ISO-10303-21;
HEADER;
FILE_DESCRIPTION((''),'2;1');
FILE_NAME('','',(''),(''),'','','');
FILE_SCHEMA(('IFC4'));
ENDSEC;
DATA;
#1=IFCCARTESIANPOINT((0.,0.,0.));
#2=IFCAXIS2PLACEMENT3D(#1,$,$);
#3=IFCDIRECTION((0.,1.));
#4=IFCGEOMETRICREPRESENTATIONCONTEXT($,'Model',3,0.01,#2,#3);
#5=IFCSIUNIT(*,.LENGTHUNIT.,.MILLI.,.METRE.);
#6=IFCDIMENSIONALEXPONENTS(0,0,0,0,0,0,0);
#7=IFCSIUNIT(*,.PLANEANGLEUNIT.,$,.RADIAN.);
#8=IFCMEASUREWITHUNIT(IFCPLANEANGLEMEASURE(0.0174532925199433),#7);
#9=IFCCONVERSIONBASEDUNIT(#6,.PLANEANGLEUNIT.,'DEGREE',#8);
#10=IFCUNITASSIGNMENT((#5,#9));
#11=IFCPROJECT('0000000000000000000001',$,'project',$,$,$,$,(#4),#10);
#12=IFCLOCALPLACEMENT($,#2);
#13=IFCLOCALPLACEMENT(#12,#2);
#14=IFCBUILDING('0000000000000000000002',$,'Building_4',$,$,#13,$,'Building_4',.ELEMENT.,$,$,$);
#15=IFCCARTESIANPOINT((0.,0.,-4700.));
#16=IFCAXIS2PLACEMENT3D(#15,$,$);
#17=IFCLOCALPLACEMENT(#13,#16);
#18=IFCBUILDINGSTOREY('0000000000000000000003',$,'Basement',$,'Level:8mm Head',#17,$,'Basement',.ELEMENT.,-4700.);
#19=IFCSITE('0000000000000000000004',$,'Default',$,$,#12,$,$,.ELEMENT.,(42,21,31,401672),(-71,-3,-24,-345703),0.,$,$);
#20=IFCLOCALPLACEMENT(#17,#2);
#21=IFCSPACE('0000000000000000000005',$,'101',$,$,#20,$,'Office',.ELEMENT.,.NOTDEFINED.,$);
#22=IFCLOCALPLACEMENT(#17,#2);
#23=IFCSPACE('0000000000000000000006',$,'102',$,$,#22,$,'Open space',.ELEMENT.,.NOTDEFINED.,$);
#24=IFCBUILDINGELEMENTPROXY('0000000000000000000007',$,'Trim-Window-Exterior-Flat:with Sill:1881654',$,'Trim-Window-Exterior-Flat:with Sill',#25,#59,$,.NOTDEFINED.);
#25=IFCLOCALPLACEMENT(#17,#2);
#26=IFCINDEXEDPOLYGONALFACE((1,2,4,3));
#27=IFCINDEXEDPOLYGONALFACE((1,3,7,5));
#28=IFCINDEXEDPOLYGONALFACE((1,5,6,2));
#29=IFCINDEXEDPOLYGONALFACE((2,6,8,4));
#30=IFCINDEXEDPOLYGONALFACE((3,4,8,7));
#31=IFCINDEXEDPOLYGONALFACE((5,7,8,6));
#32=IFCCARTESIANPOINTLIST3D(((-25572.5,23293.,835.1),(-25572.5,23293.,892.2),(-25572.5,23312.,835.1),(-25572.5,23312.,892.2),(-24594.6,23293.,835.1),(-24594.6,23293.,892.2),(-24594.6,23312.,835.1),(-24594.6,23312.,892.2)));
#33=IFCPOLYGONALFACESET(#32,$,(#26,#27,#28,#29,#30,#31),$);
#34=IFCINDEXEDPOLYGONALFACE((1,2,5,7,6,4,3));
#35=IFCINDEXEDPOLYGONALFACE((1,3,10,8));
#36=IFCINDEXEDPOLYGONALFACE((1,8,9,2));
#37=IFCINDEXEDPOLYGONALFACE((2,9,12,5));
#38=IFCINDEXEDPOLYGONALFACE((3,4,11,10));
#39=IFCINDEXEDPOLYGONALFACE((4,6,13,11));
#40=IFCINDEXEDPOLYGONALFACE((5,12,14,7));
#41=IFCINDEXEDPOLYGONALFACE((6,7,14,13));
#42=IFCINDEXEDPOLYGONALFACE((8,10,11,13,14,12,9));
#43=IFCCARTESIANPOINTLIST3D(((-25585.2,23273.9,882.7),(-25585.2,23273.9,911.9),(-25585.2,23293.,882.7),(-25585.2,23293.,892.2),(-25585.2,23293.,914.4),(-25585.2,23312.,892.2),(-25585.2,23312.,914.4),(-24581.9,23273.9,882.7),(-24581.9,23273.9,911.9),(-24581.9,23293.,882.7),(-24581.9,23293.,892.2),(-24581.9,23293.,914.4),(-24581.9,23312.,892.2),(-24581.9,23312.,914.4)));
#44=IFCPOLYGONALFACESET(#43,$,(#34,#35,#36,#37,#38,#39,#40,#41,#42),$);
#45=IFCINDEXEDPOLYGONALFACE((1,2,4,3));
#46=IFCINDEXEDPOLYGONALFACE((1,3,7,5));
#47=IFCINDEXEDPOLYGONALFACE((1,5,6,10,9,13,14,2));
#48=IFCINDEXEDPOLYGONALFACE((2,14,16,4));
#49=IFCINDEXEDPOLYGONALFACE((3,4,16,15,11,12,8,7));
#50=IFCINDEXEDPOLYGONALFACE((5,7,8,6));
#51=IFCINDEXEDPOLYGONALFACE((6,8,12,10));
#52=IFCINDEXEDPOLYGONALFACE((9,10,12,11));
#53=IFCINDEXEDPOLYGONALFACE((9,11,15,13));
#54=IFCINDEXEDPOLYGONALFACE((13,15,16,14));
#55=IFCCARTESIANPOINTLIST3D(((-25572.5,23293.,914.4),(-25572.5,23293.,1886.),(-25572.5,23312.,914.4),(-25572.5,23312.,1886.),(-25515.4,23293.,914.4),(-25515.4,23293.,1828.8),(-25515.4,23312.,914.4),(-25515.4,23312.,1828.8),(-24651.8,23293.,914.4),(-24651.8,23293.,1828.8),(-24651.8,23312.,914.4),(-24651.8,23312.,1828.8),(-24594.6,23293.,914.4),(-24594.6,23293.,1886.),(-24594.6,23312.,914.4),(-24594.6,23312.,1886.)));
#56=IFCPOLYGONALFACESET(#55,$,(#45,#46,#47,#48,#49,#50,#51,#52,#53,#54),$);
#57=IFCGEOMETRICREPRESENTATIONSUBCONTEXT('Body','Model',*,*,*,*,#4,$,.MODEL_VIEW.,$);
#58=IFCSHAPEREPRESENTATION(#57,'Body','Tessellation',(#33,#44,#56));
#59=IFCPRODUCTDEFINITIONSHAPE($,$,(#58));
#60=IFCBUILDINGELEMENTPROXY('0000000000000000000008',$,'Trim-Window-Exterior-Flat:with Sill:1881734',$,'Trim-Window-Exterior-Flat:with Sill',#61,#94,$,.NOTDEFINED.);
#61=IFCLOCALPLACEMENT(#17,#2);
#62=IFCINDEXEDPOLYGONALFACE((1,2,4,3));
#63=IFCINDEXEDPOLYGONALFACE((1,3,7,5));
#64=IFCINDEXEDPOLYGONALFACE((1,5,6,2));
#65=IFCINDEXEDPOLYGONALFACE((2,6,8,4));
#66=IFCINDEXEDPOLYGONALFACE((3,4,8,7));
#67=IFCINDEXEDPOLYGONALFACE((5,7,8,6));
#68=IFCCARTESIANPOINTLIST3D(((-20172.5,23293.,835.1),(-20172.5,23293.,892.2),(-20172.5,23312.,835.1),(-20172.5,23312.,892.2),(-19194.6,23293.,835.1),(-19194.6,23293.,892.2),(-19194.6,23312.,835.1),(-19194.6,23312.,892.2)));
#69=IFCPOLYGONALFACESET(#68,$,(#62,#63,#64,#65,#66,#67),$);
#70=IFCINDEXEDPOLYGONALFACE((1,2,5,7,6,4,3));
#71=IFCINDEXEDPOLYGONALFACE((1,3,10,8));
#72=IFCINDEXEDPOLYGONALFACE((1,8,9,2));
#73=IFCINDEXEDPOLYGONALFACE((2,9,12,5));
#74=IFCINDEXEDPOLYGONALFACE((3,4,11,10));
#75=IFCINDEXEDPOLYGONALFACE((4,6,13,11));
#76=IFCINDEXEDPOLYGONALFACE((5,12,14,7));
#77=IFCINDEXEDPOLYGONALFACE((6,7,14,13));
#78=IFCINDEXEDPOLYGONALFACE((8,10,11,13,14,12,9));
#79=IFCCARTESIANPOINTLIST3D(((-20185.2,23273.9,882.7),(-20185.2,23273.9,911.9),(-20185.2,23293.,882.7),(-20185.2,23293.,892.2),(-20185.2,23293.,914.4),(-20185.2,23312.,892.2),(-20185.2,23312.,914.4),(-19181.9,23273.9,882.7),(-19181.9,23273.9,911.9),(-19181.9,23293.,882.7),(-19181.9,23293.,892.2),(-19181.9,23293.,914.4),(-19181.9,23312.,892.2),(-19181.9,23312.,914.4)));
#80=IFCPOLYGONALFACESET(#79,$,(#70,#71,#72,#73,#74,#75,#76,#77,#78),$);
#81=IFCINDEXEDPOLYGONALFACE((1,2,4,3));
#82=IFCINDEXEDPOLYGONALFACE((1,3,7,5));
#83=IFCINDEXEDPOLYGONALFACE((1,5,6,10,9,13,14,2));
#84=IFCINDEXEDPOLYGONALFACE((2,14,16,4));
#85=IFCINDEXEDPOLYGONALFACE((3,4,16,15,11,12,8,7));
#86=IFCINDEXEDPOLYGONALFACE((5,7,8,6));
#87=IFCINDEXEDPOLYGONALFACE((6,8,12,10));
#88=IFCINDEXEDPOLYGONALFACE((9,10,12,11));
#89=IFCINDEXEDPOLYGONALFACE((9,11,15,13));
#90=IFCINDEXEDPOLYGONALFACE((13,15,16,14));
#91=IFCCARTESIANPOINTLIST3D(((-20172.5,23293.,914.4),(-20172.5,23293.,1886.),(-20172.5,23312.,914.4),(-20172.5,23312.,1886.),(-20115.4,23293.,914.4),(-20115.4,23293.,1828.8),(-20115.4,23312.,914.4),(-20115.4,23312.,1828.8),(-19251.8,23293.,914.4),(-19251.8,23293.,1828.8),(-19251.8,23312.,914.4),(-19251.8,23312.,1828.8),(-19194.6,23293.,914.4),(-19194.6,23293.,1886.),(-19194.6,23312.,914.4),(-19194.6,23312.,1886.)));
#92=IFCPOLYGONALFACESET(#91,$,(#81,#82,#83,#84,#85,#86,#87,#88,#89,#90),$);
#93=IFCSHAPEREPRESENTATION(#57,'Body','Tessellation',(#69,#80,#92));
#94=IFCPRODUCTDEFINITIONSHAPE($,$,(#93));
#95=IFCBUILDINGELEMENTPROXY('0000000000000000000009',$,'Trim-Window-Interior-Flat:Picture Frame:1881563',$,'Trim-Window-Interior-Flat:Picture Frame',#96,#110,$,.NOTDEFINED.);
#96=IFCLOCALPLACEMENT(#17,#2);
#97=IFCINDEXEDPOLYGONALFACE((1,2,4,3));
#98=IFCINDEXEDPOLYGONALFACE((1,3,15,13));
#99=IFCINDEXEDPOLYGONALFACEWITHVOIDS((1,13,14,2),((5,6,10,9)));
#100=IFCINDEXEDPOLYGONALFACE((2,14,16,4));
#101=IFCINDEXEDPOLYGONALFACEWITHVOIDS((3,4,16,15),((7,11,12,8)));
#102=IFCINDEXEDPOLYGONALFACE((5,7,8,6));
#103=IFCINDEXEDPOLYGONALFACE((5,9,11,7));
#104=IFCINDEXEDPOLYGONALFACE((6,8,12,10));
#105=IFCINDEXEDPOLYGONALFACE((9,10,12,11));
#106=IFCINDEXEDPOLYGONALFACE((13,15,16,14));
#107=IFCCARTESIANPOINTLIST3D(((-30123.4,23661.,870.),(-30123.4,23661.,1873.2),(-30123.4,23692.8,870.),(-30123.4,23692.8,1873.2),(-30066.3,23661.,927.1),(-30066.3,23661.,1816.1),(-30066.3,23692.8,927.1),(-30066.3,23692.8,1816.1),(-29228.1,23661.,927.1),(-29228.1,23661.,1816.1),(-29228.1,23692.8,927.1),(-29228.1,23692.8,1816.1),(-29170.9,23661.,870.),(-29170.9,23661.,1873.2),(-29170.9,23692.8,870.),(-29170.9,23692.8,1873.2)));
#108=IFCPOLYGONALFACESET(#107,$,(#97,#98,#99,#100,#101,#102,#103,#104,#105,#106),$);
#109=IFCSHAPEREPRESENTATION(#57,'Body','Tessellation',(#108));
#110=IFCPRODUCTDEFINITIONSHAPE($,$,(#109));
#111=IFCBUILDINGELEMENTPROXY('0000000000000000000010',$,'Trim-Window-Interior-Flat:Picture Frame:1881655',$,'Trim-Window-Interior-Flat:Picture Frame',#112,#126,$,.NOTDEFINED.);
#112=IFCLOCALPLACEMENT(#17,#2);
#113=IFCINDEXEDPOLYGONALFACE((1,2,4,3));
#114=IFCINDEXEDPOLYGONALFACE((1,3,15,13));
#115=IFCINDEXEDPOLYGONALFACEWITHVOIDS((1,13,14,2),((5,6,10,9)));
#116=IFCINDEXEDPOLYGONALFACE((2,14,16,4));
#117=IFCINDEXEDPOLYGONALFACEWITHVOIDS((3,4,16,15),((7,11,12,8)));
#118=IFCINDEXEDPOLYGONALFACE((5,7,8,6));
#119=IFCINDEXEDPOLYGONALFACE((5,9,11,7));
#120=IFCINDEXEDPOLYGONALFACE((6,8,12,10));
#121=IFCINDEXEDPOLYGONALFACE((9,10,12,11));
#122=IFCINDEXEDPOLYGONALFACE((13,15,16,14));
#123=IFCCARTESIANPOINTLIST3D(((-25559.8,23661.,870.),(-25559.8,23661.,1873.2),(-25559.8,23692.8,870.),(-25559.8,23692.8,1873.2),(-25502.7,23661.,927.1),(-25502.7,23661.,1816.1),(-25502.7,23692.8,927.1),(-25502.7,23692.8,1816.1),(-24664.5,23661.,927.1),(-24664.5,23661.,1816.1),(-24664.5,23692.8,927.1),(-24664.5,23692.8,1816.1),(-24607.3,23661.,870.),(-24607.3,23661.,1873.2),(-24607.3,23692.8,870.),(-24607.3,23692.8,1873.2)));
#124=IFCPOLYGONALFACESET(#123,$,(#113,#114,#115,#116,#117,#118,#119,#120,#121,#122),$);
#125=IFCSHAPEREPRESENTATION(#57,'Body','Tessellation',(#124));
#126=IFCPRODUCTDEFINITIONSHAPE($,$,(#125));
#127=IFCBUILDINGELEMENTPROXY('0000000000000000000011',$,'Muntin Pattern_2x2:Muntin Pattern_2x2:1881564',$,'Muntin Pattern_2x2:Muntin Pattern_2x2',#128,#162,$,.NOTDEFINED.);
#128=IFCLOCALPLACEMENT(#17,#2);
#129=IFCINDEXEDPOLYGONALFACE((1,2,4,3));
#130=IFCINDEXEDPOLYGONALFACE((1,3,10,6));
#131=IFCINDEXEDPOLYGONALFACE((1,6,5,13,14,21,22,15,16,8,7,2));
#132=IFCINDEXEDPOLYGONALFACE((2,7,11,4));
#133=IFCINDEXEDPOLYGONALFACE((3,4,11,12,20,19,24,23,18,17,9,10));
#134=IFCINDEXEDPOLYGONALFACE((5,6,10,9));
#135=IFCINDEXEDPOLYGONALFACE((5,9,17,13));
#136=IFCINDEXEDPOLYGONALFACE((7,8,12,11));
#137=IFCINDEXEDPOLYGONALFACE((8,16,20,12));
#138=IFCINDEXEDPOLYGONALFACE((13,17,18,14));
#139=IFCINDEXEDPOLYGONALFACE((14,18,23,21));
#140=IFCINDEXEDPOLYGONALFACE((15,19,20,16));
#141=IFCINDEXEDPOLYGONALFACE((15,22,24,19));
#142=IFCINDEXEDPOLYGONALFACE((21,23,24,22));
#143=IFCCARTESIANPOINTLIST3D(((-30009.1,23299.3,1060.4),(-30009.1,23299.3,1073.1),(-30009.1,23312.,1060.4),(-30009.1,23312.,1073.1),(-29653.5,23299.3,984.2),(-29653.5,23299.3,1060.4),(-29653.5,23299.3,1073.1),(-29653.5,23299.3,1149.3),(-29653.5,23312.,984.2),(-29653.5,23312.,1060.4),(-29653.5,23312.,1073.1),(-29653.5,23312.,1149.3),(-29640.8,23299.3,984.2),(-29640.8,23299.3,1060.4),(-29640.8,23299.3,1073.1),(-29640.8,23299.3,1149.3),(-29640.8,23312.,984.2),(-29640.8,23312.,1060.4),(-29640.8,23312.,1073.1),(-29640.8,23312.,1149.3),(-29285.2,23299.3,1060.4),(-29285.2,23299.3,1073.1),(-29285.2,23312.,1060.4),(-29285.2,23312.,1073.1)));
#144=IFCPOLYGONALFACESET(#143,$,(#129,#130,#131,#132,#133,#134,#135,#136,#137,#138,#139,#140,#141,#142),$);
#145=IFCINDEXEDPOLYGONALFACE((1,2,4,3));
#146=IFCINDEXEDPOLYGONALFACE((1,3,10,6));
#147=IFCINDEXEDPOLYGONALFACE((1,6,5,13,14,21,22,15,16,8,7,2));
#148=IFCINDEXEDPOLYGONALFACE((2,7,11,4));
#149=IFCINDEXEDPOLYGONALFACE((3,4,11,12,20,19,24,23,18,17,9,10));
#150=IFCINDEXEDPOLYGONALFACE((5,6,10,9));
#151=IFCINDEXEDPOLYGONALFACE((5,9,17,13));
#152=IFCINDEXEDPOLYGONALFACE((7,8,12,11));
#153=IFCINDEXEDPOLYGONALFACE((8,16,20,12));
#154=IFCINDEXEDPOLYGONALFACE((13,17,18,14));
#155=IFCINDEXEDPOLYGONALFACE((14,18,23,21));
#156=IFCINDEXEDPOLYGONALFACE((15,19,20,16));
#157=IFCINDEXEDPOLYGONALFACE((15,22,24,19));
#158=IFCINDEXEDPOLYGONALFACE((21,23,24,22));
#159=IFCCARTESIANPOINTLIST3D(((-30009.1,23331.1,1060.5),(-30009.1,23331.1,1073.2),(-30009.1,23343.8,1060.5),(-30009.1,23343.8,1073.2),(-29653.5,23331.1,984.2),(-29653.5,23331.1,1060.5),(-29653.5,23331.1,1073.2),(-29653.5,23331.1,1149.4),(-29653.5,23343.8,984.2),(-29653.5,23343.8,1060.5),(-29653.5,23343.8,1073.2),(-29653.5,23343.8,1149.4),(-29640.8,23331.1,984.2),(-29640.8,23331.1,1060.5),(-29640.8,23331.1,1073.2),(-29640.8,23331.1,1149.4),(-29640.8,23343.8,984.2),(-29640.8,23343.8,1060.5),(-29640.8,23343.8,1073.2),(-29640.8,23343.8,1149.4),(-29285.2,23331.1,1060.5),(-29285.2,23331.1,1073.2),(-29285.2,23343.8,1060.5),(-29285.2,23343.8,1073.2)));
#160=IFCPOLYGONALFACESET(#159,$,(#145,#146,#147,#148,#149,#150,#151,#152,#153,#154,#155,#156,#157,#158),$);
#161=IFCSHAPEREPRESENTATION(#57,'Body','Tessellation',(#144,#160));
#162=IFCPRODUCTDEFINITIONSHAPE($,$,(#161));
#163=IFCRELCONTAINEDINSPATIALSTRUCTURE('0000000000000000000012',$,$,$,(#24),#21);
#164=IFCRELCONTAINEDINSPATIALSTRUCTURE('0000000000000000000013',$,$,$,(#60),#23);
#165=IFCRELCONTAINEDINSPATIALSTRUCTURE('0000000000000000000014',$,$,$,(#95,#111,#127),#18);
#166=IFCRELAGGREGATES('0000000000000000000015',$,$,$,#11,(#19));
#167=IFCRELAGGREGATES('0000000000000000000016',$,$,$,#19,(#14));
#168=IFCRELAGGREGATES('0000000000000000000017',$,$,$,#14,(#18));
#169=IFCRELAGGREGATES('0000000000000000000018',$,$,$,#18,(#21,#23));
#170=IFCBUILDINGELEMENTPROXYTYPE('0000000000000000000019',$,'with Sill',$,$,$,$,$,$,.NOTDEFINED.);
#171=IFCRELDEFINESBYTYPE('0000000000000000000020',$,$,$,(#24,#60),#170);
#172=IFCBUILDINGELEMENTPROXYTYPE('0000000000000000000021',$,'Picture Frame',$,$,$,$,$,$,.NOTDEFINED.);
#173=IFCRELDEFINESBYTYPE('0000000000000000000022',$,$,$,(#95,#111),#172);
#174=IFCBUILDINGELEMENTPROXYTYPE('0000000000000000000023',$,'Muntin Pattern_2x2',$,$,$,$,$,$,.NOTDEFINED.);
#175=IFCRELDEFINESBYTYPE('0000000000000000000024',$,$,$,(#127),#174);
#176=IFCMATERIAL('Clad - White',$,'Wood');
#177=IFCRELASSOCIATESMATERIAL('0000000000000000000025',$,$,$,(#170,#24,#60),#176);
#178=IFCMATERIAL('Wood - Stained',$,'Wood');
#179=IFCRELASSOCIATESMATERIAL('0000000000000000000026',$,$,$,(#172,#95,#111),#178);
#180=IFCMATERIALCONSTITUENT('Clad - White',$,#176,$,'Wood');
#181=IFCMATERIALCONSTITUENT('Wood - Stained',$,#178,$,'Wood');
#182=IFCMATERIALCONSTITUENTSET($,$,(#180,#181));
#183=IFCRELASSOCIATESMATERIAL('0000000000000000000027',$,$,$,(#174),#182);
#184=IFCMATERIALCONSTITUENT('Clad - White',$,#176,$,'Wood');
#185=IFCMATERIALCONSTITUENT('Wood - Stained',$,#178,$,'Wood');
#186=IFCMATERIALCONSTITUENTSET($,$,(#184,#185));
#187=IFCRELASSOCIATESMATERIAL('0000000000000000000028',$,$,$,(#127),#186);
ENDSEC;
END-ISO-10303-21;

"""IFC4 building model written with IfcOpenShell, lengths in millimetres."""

from ifc_helpers import new_model, entity, si_unit, converted_unit, direction, frame, origin, place, context, subcontext, project, spatial, indexed_curve, outline, extrude, source, transform, mapped, material, constituent, constituent_set, type_object, type_shapes, element, save


model = new_model("IFC4")

# Units and contexts
model_context = context("Model", 3, precision=0.01, world=origin(), true_north=direction((0.0, 1.0)))
body_context = subcontext(model_context, "Body", "Model", "MODEL_VIEW")
ifc_project = project(units=[si_unit("LENGTHUNIT", "METRE", prefix="MILLI"), converted_unit("PLANEANGLEUNIT", "DEGREE", entity("IfcPlaneAngleMeasure", 0.0174532925199433), si_unit("PLANEANGLEUNIT", "RADIAN"), dimensions=[0, 0, 0, 0, 0, 0, 0])], contexts=[model_context])

# Site, building, storey
site_placement = place(None, origin())
site = spatial("IfcSite", under=ifc_project, at=site_placement, Name="Default", CompositionType="ELEMENT", RefLatitude=(42, 21, 31, 401672), RefLongitude=(-71, -3, -24, -345703), RefElevation=0.0)
building_placement = place(site_placement, origin())
building = spatial("IfcBuilding", under=site, at=building_placement, Name="Building_4", LongName="Building_4", CompositionType="ELEMENT")
storey_placement = place(building_placement, frame((0.0, 0.0, -4700.0)))
storey = spatial("IfcBuildingStorey", under=building, at=storey_placement, Name="Basement", ObjectType="Level:8mm Head", LongName="Basement", CompositionType="ELEMENT", Elevation=-4700.0)

# Shared definitions
ifc_material_1 = material(Name="Clad - White", Category="Wood")
ifc_material_2 = material(Name="Wood - Stained", Category="Wood")

# Shared definitions
building_element_proxy_type_1 = type_object("IfcBuildingElementProxyType", Name="with Sill", PredefinedType="NOTDEFINED", material=ifc_material_1)
shared_shape_1 = source(origin(), body_context, "Body", "SweptSolid", [
    extrude(outline(indexed_curve([(-488.9, -28.6), (488.9, -28.6), (488.9, 28.6), (-488.9, 28.6), (-488.9, -28.6)], self_intersect=False)), frame((0.0, -965.2, 0.0), z_axis=(0.0, 0.0, 1.0), x_axis=(-1.0, 0.0, 0.0)), (0.0, 0.0, 1.0), 19.1),
    extrude(outline(indexed_curve([(-19.0, -16.0), (0.0, -16.0), (0.0, -6.4), (19.0, -6.4), (19.0, 15.8), (0.0, 15.8), (-19.0, 13.3), (-19.0, -16.0)], self_intersect=False)), frame((-501.6, -930.2, 19.0), z_axis=(1.0, 0.0, 0.0), x_axis=(0.0, 0.0, -1.0)), (0.0, 0.0, 1.0), 1003.3),
    extrude(outline(indexed_curve([(-500.1, -488.9), (471.5, -488.9), (471.5, -431.8), (-442.9, -431.8), (-442.9, 431.8), (471.5, 431.8), (471.5, 488.9), (-500.1, 488.9), (-500.1, -488.9)], self_intersect=False)), frame((0.0, -442.9, 0.0), z_axis=(0.0, 0.0, 1.0), x_axis=(0.0, -1.0, 0.0)), (0.0, 0.0, 1.0), 19.1),
])
type_shapes(building_element_proxy_type_1, [shared_shape_1])

# Shared definitions
space_1_placement = place(storey_placement, origin())
space_1 = spatial("IfcSpace", under=storey, at=space_1_placement, Name="101", LongName="Office", CompositionType="ELEMENT", PredefinedType="NOTDEFINED")

# Building element proxy
proxy_1_placement = place(space_1_placement, frame((-25083.6, 23312.0, 1828.8), z_axis=(0.0, -1.0, 0.0), x_axis=(1.0, 0.0, 0.0)))
element("IfcBuildingElementProxy", 1, at=proxy_1_placement, inside=space_1, type_object=building_element_proxy_type_1, material=ifc_material_1, Name="Trim-Window-Exterior-Flat:with Sill:1881654", ObjectType="Trim-Window-Exterior-Flat:with Sill", PredefinedType="NOTDEFINED", context=body_context, shape_type="MappedRepresentation", body=[
    mapped(shared_shape_1, transform((0.0, 0.0, 0.0), scale=1.0)),
])

# Shared definitions
space_2_placement = place(storey_placement, origin())
space_2 = spatial("IfcSpace", under=storey, at=space_2_placement, Name="102", LongName="Open space", CompositionType="ELEMENT", PredefinedType="NOTDEFINED")

# Building element proxies
proxy_2_placement = place(space_2_placement, frame((-19683.6, 23312.0, 1828.8), z_axis=(0.0, -1.0, 0.0), x_axis=(1.0, 0.0, 0.0)))
element("IfcBuildingElementProxy", 2, at=proxy_2_placement, inside=space_2, type_object=building_element_proxy_type_1, material=ifc_material_1, Name="Trim-Window-Exterior-Flat:with Sill:1881734", ObjectType="Trim-Window-Exterior-Flat:with Sill", PredefinedType="NOTDEFINED", context=body_context, shape_type="MappedRepresentation", body=[
    mapped(shared_shape_1, transform((0.0, 0.0, 0.0), scale=1.0)),
])
building_element_proxy_type_2 = type_object("IfcBuildingElementProxyType", Name="Picture Frame", PredefinedType="NOTDEFINED", material=ifc_material_2)
shared_shape_2 = source(origin(), body_context, "Body", "SweptSolid", [
    extrude(outline(indexed_curve([(-476.2, -501.6), (476.2, -501.6), (476.2, 501.6), (-476.2, 501.6), (-476.2, -501.6)], self_intersect=False), holes=[indexed_curve([(-419.1, -444.5), (-419.1, 444.5), (419.1, 444.5), (419.1, -444.5), (-419.1, -444.5)], self_intersect=False)]), frame((0.0, -457.2, 0.0), z_axis=(0.0, 0.0, 1.0), x_axis=(-1.0, 0.0, 0.0)), (0.0, 0.0, 1.0), 31.8),
])
type_shapes(building_element_proxy_type_2, [shared_shape_2])
for number, where, z_axis, x_axis, name in (
    (3, (-29647.2, 23661.0, 1828.8), (0.0, 1.0, 0.0), (-1.0, 0.0, 0.0), "Trim-Window-Interior-Flat:Picture Frame:1881563"),
    (4, (-25083.6, 23661.0, 1828.8), (0.0, 1.0, 0.0), (-1.0, 0.0, 0.0), "Trim-Window-Interior-Flat:Picture Frame:1881655"),
):
    element("IfcBuildingElementProxy", number, at=place(storey_placement, frame(where, z_axis=z_axis, x_axis=x_axis)), inside=storey, type_object=building_element_proxy_type_2, material=ifc_material_2, Name=name, ObjectType="Trim-Window-Interior-Flat:Picture Frame", PredefinedType="NOTDEFINED", context=body_context, shape_type="MappedRepresentation", body=[
        mapped(shared_shape_2, transform((0.0, 0.0, 0.0), scale=1.0)),
    ])
ifc_constituent_1 = constituent(ifc_material_1, Name="Clad - White", Category="Wood")
ifc_constituent_2 = constituent(ifc_material_2, Name="Wood - Stained", Category="Wood")
ifc_constituent_set_1 = constituent_set(constituents=[ifc_constituent_1, ifc_constituent_2])
ifc_constituent_3 = constituent(ifc_material_1, Name="Clad - White", Category="Wood")
ifc_constituent_4 = constituent(ifc_material_2, Name="Wood - Stained", Category="Wood")
ifc_constituent_set_2 = constituent_set(constituents=[ifc_constituent_3, ifc_constituent_4])
building_element_proxy_type_3 = type_object("IfcBuildingElementProxyType", Name="Muntin Pattern_2x2", PredefinedType="NOTDEFINED", material=ifc_constituent_set_2)
shared_shape_3 = source(origin(), body_context, "Body", "SweptSolid", [
    extrude(outline(indexed_curve([(6.4, -6.4), (82.5, -6.4), (82.5, 6.3), (6.4, 6.3), (6.4, 362.0), (-6.3, 362.0), (-6.3, 6.3), (-82.6, 6.3), (-82.6, -6.4), (-6.3, -6.4), (-6.3, -361.9), (6.4, -361.9), (6.4, -6.4)], self_intersect=False)), frame((0.0, -22.2, 82.5), z_axis=(0.0, 1.0, 0.0), x_axis=(0.0, 0.0, 1.0)), (0.0, 0.0, 1.0), 12.7),
    extrude(outline(indexed_curve([(6.4, -6.4), (82.6, -6.4), (82.6, 6.3), (6.4, 6.3), (6.4, 362.0), (-6.3, 362.0), (-6.3, 6.3), (-82.6, 6.3), (-82.6, -6.4), (-6.3, -6.4), (-6.3, -361.9), (6.4, -361.9), (6.4, -6.4)], self_intersect=False)), frame((0.0, 9.5, 82.6), z_axis=(0.0, 1.0, 0.0), x_axis=(0.0, 0.0, 1.0)), (0.0, 0.0, 1.0), 12.7),
])
type_shapes(building_element_proxy_type_3, [shared_shape_3])
proxy_3_placement = place(storey_placement, frame((-29647.2, 23321.5, 984.2)))
element("IfcBuildingElementProxy", 5, at=proxy_3_placement, inside=storey, type_object=building_element_proxy_type_3, material=ifc_constituent_set_1, Name="Muntin Pattern_2x2:Muntin Pattern_2x2:1881564", ObjectType="Muntin Pattern_2x2:Muntin Pattern_2x2", PredefinedType="NOTDEFINED", context=body_context, shape_type="MappedRepresentation", body=[
    mapped(shared_shape_3, transform((0.0, 0.0, 0.0), scale=1.0)),
])

save(model, "model.ifc")
